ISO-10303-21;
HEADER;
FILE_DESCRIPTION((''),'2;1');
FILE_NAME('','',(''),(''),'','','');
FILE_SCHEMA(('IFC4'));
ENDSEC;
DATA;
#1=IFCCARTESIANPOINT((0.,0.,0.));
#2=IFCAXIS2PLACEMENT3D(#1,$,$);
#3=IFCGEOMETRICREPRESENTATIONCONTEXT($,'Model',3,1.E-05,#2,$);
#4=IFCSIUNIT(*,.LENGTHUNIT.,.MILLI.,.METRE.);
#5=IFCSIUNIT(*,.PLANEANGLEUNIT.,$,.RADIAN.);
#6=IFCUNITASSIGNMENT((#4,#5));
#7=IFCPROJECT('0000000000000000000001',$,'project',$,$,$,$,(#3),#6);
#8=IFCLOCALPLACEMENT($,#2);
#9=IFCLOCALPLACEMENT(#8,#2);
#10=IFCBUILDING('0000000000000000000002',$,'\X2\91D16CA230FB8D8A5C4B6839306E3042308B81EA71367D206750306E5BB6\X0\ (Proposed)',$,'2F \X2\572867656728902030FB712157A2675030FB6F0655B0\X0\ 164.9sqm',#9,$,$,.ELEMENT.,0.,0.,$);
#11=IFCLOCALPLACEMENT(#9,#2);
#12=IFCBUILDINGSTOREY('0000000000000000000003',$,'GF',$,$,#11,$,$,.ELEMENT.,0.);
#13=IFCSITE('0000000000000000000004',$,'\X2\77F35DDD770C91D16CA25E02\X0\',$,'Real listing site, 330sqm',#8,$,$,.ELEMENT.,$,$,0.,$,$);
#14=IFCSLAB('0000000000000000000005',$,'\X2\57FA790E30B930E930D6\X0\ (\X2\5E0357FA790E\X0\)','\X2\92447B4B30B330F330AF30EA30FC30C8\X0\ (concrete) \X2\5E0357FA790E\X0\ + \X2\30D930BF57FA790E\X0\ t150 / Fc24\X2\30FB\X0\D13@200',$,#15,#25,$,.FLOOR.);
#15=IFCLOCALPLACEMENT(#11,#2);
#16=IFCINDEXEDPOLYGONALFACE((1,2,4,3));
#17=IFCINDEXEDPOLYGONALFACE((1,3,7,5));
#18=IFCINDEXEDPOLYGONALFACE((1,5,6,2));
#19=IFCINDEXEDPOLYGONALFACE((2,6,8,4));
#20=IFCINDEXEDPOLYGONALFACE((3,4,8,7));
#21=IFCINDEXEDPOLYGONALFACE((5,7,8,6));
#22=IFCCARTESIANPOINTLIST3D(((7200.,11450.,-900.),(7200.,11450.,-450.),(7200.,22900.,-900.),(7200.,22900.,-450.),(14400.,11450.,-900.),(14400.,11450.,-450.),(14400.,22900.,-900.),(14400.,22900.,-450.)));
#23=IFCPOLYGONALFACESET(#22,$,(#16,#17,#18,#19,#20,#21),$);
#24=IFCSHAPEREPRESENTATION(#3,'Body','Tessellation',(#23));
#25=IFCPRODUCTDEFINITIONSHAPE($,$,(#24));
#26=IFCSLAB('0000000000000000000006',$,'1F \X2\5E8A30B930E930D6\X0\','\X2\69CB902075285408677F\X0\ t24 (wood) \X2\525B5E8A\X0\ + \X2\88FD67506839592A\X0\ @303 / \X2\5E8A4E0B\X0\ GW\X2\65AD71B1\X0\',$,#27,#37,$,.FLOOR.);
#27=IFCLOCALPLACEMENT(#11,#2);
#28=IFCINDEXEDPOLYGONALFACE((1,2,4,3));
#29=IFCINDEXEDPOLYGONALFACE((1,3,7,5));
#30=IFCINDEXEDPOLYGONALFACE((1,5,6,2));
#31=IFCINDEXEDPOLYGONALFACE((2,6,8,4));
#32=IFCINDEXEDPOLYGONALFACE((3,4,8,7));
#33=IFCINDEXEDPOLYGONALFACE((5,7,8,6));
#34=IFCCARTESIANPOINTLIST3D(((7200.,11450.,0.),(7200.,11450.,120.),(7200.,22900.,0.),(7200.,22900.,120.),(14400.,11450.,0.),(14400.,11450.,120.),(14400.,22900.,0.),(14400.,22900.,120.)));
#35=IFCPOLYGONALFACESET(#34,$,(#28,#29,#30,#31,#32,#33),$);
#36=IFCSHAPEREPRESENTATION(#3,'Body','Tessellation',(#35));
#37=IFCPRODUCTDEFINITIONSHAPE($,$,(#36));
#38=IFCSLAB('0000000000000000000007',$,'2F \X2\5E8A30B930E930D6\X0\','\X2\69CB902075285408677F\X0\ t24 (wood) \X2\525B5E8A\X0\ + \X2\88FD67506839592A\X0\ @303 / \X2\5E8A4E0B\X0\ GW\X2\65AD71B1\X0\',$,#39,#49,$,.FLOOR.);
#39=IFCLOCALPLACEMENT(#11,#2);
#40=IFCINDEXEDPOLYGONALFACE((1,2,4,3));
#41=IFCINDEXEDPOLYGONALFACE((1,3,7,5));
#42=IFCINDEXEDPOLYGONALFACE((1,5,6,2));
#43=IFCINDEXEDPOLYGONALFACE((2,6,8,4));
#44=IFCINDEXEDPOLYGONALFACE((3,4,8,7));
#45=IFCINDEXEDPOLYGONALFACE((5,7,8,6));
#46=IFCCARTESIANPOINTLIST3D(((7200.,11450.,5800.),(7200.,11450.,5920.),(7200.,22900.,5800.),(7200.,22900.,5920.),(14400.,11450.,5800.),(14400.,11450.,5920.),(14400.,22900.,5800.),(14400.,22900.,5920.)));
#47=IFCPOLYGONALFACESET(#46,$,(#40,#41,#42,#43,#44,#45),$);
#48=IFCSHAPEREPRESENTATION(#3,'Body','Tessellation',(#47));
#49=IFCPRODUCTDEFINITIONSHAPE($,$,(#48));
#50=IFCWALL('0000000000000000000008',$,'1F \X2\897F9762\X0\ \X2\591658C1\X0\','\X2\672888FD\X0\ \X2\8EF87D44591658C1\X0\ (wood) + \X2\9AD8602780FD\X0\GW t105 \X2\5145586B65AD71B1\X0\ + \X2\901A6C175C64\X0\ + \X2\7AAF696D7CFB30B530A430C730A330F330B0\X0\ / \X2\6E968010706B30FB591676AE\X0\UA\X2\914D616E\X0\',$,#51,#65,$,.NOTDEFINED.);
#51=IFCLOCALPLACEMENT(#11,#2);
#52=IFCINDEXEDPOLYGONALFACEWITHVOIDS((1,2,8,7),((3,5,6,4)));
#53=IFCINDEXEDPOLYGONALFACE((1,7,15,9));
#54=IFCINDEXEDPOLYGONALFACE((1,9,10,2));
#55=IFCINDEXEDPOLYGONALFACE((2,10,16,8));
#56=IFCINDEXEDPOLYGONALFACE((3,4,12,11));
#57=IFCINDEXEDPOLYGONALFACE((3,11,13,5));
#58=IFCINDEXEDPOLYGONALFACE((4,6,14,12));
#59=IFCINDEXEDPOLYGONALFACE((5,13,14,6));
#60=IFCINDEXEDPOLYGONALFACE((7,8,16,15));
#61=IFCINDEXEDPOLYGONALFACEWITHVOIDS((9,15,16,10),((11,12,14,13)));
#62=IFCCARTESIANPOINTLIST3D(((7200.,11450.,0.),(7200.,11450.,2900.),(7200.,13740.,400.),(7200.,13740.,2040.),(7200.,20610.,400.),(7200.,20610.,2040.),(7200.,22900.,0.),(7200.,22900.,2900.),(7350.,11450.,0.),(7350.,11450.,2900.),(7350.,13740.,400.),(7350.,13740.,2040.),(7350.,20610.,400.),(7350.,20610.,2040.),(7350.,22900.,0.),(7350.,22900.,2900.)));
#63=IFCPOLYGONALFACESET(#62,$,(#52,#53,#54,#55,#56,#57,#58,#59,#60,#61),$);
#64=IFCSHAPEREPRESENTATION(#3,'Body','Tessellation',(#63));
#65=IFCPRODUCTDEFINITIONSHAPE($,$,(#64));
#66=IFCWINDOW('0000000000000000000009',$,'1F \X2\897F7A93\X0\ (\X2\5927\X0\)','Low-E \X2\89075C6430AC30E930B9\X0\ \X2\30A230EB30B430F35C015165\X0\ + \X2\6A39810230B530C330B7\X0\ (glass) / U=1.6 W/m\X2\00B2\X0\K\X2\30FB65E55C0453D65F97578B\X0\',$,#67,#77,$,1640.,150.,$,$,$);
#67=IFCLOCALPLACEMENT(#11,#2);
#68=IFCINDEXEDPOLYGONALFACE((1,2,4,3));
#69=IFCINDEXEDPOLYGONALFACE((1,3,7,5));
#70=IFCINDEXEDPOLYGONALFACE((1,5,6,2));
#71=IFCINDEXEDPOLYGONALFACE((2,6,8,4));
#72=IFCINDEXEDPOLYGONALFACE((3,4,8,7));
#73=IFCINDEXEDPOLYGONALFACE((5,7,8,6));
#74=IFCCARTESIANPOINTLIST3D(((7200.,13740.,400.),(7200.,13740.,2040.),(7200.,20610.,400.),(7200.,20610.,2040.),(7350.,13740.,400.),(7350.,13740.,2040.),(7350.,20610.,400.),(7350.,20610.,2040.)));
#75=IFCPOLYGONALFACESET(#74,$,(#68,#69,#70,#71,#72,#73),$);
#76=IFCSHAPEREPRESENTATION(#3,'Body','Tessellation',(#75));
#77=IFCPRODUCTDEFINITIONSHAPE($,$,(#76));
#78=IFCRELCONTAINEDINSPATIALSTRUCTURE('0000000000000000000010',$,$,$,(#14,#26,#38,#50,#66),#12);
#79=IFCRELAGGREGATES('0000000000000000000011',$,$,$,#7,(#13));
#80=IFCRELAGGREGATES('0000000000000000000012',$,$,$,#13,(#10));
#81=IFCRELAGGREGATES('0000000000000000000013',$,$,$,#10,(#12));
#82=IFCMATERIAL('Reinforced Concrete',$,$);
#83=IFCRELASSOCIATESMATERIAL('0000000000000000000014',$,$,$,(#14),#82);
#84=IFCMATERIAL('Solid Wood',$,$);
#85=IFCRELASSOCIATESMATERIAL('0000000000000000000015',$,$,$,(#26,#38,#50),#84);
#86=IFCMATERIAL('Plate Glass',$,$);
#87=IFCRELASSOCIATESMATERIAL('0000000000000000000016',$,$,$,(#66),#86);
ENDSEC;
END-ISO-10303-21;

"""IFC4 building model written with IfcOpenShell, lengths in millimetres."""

from ifc_helpers import new_model, si_unit, frame, frame_2d, origin, place, context, project, spatial, rectangle, extrude, material, element, fill, save


model = new_model("IFC4")

# Units and contexts
model_context = context("Model", 3, precision=1e-05, world=origin())
ifc_project = project(units=[si_unit("LENGTHUNIT", "METRE", prefix="MILLI"), si_unit("PLANEANGLEUNIT", "RADIAN")], contexts=[model_context])

# Site, building, storey
site_placement = place(None, origin())
site = spatial("IfcSite", under=ifc_project, at=site_placement, Name="石川県金沢市", ObjectType="Real listing site, 330sqm", CompositionType="ELEMENT", RefElevation=0.0)
building_placement = place(site_placement, origin())
building = spatial("IfcBuilding", under=site, at=building_placement, Name="金沢・越屋根のある自然素材の家 (Proposed)", ObjectType="2F 在来木造・無垢材・漆喰 164.9sqm", CompositionType="ELEMENT", ElevationOfRefHeight=0.0, ElevationOfTerrain=0.0)
storey_placement = place(building_placement, origin())
storey = spatial("IfcBuildingStorey", under=building, at=storey_placement, Name="GF", CompositionType="ELEMENT", Elevation=0.0)

# Shared definitions
ifc_material_1 = material(Name="Solid Wood")

# Slabs
ifc_material_2 = material(Name="Reinforced Concrete")
slab_1_placement = place(storey_placement, frame((3600.0, 5725.0, -450.0)))
element("IfcSlab", 1, at=slab_1_placement, inside=storey, material=ifc_material_2, Name="基礎スラブ (布基礎)", Description="鉄筋コンクリート (concrete) 布基礎 + ベタ基礎 t150 / Fc24・D13@200", PredefinedType="FLOOR", context=model_context, shape_type="SweptSolid", body=[
    extrude(rectangle(XDim=7200.0, YDim=11450.0, at=frame_2d((3600.0, 5725.0))), frame((3600.0, 5725.0, -450.0)), (0.0, 0.0, 1.0), 450.0),
])
slab_2_placement = place(storey_placement, frame((3600.0, 5725.0, 0.0)))
element("IfcSlab", 2, at=slab_2_placement, inside=storey, material=ifc_material_1, Name="1F 床スラブ", Description="構造用合板 t24 (wood) 剛床 + 製材根太 @303 / 床下 GW断熱", PredefinedType="FLOOR", context=model_context, shape_type="SweptSolid", body=[
    extrude(rectangle(XDim=7200.0, YDim=11450.0, at=frame_2d((3600.0, 5725.0))), frame((3600.0, 5725.0, 0.0)), (0.0, 0.0, 1.0), 120.0),
])
slab_3_placement = place(storey_placement, frame((3600.0, 5725.0, 2900.0)))
element("IfcSlab", 3, at=slab_3_placement, inside=storey, material=ifc_material_1, Name="2F 床スラブ", Description="構造用合板 t24 (wood) 剛床 + 製材根太 @303 / 床下 GW断熱", PredefinedType="FLOOR", context=model_context, shape_type="SweptSolid", body=[
    extrude(rectangle(XDim=7200.0, YDim=11450.0, at=frame_2d((3600.0, 5725.0))), frame((3600.0, 5725.0, 2900.0)), (0.0, 0.0, 1.0), 120.0),
])

# Shared definitions
ifc_material_3 = material(Name="Plate Glass")

# Wall, opening, window
wall_1_placement = place(storey_placement, frame((3600.0, 5725.0, 0.0)))
wall_1 = element("IfcWall", 4, at=wall_1_placement, inside=storey, material=ifc_material_1, Name="1F 西面 外壁", Description="木製 軸組外壁 (wood) + 高性能GW t105 充填断熱 + 通気層 + 窯業系サイディング / 準耐火・外皮UA配慮", PredefinedType="NOTDEFINED", context=model_context, shape_type="SweptSolid", body=[
    extrude(rectangle(XDim=150.0, YDim=11450.0, at=frame_2d((75.0, 5725.0))), frame((3600.0, 5725.0, 0.0)), (0.0, 0.0, 1.0), 2900.0),
])
opening_1_placement = place(storey_placement, frame((3600.0, 6870.0, 200.0)))
opening_1 = element("IfcOpeningElement", 5, at=opening_1_placement, cuts=wall_1, PredefinedType="NOTDEFINED", context=model_context, shape_type="SweptSolid", body=[
    extrude(rectangle(XDim=150.0, YDim=6870.0, at=frame_2d((75.0, 3435.0))), frame((3600.0, 6870.0, 200.0)), (0.0, 0.0, 1.0), 1640.0),
])
window_1_placement = place(storey_placement, frame((3600.0, 6870.0, 200.0)))
window_1 = element("IfcWindow", 6, at=window_1_placement, inside=storey, material=ifc_material_3, Name="1F 西窓 (大)", Description="Low-E 複層ガラス アルゴン封入 + 樹脂サッシ (glass) / U=1.6 W/m²K・日射取得型", OverallHeight=1640.0, OverallWidth=150.0, context=model_context, shape_type="SweptSolid", body=[
    extrude(rectangle(XDim=150.0, YDim=6870.0, at=frame_2d((75.0, 3435.0))), frame((3600.0, 6870.0, 200.0)), (0.0, 0.0, 1.0), 1640.0),
])
fill(opening_1, window_1)

save(model, "model.ifc")
